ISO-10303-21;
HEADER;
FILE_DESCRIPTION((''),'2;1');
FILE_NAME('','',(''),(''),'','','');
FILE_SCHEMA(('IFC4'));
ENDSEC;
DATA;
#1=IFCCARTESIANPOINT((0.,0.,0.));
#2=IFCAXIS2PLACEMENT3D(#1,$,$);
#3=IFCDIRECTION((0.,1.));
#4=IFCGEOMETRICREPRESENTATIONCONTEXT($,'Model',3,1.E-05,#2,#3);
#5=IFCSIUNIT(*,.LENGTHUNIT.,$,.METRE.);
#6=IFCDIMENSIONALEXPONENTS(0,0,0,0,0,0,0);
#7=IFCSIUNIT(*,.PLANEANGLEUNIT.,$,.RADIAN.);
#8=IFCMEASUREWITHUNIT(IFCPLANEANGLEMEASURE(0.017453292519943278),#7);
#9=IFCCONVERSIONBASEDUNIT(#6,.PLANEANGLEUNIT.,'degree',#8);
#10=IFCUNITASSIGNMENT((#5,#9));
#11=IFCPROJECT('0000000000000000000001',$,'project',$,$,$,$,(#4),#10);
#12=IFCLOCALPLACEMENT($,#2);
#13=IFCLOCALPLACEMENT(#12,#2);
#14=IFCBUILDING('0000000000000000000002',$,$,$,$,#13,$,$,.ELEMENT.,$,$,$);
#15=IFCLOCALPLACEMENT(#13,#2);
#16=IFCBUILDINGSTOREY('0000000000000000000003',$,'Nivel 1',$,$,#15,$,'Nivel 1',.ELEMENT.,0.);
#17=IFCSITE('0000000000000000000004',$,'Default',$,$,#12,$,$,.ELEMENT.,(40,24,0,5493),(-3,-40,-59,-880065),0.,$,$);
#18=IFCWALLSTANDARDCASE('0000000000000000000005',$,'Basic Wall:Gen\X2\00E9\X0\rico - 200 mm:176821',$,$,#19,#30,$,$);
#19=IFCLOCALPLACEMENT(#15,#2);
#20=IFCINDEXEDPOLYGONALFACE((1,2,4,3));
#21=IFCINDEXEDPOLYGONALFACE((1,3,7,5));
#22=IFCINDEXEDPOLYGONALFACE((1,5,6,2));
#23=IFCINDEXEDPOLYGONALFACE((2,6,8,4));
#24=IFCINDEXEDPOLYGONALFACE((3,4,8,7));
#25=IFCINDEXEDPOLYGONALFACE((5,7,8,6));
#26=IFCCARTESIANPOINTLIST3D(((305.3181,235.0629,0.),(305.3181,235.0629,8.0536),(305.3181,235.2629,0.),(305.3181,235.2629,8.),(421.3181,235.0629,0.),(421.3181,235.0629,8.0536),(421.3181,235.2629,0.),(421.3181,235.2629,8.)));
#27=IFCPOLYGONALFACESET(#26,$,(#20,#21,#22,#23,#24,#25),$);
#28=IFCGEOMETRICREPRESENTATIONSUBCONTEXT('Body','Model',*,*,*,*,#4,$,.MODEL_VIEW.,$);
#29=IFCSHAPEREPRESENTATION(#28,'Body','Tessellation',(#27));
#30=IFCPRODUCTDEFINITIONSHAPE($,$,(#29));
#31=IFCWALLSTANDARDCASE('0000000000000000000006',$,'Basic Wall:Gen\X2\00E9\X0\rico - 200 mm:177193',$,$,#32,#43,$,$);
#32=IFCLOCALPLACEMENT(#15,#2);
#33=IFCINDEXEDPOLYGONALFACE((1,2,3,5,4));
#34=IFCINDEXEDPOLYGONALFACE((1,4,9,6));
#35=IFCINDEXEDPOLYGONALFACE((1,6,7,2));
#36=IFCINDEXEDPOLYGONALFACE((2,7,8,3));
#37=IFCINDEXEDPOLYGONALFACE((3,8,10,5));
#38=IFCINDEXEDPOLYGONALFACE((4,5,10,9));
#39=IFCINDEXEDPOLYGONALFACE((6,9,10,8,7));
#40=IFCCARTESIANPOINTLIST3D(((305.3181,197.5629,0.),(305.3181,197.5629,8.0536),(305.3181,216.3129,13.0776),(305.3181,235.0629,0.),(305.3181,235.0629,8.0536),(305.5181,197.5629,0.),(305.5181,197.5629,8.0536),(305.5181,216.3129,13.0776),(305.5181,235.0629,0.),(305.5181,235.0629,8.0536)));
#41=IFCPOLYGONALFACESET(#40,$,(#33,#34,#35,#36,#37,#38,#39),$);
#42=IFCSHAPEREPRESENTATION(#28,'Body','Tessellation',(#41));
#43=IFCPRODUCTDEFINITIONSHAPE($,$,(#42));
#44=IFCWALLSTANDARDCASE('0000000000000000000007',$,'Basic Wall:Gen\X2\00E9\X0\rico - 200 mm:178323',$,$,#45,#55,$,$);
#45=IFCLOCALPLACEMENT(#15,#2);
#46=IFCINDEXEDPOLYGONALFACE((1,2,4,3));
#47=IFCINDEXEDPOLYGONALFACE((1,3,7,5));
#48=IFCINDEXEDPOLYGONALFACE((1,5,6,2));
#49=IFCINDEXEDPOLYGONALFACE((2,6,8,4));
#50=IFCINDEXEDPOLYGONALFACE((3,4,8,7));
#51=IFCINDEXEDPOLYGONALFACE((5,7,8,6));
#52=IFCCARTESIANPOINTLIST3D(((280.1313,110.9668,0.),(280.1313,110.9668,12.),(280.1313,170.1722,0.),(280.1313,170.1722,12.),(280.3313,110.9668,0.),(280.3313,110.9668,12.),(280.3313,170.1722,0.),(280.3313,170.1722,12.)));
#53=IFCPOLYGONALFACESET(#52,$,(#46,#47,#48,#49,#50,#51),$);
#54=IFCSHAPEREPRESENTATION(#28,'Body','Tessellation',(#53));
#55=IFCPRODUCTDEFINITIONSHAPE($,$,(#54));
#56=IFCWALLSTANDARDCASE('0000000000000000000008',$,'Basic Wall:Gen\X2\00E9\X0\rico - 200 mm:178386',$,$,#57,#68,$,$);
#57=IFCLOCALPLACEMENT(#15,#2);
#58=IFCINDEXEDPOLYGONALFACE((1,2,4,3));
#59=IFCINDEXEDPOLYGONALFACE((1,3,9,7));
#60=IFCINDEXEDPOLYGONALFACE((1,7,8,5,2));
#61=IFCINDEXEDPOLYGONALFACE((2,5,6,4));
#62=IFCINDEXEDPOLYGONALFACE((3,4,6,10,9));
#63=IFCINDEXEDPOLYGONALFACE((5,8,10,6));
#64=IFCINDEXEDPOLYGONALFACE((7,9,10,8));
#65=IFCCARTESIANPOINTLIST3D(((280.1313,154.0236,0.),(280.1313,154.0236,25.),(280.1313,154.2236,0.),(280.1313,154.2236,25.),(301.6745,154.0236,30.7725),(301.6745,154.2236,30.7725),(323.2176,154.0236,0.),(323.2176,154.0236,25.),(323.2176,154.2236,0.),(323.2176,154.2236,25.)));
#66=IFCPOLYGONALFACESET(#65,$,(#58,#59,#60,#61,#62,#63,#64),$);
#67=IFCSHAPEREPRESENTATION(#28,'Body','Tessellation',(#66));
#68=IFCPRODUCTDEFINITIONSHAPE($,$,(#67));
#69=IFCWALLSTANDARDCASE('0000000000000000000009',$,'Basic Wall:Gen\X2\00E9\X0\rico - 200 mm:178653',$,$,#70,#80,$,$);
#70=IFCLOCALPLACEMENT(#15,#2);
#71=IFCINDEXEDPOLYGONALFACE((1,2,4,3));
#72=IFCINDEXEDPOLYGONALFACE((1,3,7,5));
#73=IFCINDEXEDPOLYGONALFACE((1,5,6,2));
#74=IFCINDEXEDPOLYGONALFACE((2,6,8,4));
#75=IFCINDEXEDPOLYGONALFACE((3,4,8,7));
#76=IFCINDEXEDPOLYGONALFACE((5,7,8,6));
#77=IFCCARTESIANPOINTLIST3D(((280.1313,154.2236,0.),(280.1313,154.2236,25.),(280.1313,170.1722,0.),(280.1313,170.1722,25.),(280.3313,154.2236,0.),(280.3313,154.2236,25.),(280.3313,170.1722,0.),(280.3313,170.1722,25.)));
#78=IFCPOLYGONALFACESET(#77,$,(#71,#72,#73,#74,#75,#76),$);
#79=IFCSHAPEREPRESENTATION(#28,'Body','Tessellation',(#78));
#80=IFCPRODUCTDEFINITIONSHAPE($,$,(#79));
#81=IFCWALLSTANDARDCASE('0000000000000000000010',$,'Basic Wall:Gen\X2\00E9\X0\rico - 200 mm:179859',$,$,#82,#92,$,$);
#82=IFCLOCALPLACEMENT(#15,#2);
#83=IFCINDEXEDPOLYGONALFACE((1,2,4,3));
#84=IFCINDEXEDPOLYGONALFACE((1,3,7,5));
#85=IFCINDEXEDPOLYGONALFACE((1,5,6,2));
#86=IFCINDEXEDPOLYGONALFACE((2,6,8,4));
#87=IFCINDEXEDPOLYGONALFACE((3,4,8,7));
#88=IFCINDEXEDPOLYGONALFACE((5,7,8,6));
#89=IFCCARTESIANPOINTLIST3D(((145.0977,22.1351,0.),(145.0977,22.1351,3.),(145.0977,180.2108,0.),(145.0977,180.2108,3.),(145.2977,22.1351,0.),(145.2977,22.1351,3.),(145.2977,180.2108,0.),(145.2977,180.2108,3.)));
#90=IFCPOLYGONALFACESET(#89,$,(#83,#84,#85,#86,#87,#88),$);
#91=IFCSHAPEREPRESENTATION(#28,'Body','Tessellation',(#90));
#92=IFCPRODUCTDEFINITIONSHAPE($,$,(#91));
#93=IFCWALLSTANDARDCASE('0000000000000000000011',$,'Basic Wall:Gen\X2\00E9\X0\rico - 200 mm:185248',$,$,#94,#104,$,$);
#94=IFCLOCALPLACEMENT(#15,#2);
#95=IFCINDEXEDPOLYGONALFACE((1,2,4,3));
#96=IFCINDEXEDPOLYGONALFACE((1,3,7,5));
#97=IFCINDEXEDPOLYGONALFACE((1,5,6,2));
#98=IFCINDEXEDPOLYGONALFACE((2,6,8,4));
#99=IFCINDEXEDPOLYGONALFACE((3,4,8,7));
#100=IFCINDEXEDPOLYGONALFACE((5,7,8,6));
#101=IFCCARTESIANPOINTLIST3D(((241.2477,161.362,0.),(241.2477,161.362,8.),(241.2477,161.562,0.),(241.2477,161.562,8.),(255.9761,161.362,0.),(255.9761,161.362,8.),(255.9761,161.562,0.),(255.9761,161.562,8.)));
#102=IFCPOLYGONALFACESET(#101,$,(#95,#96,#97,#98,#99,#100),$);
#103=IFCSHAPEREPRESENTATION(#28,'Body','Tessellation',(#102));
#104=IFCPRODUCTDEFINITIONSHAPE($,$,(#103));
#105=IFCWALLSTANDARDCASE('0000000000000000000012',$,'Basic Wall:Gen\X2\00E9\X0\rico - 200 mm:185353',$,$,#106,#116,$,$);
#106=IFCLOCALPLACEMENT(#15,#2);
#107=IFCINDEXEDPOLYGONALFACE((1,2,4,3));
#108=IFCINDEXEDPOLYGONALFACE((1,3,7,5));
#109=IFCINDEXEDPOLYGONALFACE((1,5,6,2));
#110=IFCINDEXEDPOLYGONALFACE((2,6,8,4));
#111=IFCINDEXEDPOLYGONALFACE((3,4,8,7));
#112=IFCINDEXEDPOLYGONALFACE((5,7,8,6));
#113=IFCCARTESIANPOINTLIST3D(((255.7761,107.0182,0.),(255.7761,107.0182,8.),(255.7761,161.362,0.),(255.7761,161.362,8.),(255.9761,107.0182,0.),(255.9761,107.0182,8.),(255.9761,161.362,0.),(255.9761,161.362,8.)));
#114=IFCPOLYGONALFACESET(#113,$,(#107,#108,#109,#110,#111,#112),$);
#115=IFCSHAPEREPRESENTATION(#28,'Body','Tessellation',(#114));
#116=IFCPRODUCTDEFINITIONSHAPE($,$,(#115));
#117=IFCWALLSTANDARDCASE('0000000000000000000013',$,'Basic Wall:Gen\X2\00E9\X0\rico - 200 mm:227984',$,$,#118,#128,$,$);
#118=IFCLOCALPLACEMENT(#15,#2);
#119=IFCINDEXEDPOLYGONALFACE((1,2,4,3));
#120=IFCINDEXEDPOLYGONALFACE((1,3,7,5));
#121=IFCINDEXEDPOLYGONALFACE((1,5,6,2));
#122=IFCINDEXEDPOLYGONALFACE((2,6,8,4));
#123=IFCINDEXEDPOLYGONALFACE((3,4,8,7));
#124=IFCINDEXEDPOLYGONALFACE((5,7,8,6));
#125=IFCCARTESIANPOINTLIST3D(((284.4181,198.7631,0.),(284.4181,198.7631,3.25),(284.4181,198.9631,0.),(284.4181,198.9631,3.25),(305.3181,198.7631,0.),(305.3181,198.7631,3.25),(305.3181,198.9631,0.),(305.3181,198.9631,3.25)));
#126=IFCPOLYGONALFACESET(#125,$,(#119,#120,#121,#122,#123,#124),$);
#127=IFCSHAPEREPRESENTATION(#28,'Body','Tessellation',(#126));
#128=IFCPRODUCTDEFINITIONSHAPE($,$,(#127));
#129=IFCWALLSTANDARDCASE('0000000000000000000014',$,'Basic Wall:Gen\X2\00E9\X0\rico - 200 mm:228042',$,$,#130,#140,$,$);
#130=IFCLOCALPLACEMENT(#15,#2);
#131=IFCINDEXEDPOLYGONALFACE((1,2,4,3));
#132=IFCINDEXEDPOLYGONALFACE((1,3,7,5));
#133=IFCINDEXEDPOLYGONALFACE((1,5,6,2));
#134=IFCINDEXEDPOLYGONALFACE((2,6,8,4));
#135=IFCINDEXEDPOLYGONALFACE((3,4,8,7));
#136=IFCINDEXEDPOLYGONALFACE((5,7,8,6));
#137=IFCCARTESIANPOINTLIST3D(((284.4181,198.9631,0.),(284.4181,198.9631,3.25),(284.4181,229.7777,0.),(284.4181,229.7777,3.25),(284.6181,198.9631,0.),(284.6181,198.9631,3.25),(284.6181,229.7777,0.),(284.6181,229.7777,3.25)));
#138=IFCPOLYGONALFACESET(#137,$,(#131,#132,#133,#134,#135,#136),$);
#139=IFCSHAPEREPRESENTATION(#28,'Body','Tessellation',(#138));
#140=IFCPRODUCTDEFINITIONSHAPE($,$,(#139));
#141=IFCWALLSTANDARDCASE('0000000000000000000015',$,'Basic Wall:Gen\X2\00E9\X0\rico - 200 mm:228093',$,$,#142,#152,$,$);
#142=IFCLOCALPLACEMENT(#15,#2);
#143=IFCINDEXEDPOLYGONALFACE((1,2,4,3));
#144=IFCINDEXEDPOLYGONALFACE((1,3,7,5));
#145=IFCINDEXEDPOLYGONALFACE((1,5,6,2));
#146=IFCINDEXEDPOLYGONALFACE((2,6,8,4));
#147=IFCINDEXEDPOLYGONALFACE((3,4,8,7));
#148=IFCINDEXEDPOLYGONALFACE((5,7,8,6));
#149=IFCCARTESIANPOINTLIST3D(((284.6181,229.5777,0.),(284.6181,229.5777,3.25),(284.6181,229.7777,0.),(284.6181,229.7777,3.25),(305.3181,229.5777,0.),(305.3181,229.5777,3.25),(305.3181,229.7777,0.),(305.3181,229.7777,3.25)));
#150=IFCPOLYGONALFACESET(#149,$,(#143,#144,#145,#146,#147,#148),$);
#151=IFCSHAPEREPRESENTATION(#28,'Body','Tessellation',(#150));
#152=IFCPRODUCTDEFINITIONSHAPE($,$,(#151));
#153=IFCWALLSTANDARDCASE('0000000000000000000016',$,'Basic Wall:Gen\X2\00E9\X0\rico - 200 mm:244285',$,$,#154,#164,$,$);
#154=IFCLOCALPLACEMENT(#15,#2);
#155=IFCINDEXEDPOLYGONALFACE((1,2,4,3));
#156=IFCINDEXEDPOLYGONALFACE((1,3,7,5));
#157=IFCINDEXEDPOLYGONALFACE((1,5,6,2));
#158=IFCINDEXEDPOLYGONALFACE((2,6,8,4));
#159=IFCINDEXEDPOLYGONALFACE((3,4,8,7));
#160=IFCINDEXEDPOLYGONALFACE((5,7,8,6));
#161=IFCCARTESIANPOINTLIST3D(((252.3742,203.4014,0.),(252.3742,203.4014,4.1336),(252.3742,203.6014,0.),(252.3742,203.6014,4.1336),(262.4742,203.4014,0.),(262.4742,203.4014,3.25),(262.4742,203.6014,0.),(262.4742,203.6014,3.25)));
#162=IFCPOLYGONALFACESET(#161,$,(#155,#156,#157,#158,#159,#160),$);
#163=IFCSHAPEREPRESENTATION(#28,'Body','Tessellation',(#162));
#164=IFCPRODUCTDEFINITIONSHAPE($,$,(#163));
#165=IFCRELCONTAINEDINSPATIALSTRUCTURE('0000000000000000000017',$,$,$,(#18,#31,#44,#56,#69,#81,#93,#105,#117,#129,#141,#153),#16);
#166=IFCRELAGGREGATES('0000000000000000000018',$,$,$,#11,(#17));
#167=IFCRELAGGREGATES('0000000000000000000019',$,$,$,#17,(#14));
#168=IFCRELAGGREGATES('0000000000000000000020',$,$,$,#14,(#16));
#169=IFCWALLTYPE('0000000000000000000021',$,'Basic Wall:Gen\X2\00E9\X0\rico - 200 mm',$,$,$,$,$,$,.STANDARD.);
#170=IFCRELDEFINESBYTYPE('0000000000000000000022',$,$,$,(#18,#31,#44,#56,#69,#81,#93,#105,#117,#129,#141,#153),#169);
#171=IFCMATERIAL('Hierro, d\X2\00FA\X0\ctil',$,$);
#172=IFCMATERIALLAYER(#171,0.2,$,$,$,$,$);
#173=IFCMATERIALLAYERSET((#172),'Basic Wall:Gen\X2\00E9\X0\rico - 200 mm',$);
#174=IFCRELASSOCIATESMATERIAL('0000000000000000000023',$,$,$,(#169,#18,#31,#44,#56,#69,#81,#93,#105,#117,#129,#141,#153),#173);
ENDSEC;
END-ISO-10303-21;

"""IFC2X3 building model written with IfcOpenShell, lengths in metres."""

from ifc_helpers import new_model, entity, si_unit, converted_unit, direction, frame, frame_2d, origin, place, context, subcontext, project, spatial, polyline, rectangle, extrude, clip, bounded_halfspace, material, layer, layer_set, layer_usage, type_object, element, save


model = new_model("IFC2X3")

# Units and contexts
model_context = context("Model", 3, precision=1e-05, world=origin(), true_north=direction((0.0, 1.0)))
body_context = subcontext(model_context, "Body", "Model", "MODEL_VIEW")
ifc_project = project(units=[si_unit("LENGTHUNIT", "METRE"), converted_unit("PLANEANGLEUNIT", "degree", entity("IfcPlaneAngleMeasure", 0.017453292519943278), si_unit("PLANEANGLEUNIT", "RADIAN"), dimensions=[0, 0, 0, 0, 0, 0, 0])], contexts=[model_context])

# Site, building, storey
site_placement = place(None, origin())
site = spatial("IfcSite", under=ifc_project, at=site_placement, Name="Default", CompositionType="ELEMENT", RefLatitude=(40, 24, 0, 5493), RefLongitude=(-3, -40, -59, -880065), RefElevation=0.0)
building_placement = place(site_placement, origin())
building = spatial("IfcBuilding", under=site, at=building_placement, CompositionType="ELEMENT")
storey_placement = place(building_placement, origin())
storey = spatial("IfcBuildingStorey", under=building, at=storey_placement, Name="Nivel 1", LongName="Nivel 1", CompositionType="ELEMENT", Elevation=0.0)

# Walls
ifc_material_1 = material(Name="Hierro, dúctil")
ifc_layer_1 = layer(ifc_material_1, 0.2)
ifc_layer_set_1 = layer_set([ifc_layer_1], Name="Basic Wall:Genérico - 200 mm")
wall_type = type_object("IfcWallType", Name="Basic Wall:Genérico - 200 mm", PredefinedType="STANDARD", material=ifc_layer_set_1)
ifc_layer_usage_1 = layer_usage(ifc_layer_set_1, "AXIS2", "NEGATIVE", 0.1)
wall_1_placement = place(storey_placement, frame((305.3181, 235.1629, 0.0)))
element("IfcWallStandardCase", 1, at=wall_1_placement, inside=storey, type_object=wall_type, material=ifc_layer_usage_1, Name="Basic Wall:Genérico - 200 mm:176821", context=body_context, shape_type="Clipping", body=[
    clip(extrude(rectangle(XDim=116.0, YDim=0.2, at=frame_2d((58.0, 0.0), x_axis=(-1.0, 0.0))), origin(), (0.0, 0.0, 1.0), 8.0536), bounded_halfspace(frame((0.0, -0.1, 8.0536), z_axis=(0.0, 0.258819, 0.965926), x_axis=(-1.0, 0.0, 0.0)), False, frame((0.0, -0.1, 8.0536)), polyline([(0.0, 0.0), (0.2, 0.0), (115.8, 0.0), (116.0, 0.0), (116.0, 0.2), (0.0, 0.2), (0.0, 0.0)]))),
])
ifc_layer_usage_2 = layer_usage(ifc_layer_set_1, "AXIS2", "NEGATIVE", 0.1)
wall_2_placement = place(storey_placement, frame((305.4181, 197.5629, 0.0), z_axis=(0.0, 0.0, 1.0), x_axis=(0.0, 1.0, 0.0)))
element("IfcWallStandardCase", 2, at=wall_2_placement, inside=storey, type_object=wall_type, material=ifc_layer_usage_2, Name="Basic Wall:Genérico - 200 mm:177193", context=body_context, shape_type="Clipping", body=[
    clip(clip(extrude(rectangle(XDim=37.5, YDim=0.2, at=frame_2d((18.75, 0.0), x_axis=(-1.0, 0.0))), origin(), (0.0, 0.0, 1.0), 13.0776), bounded_halfspace(frame((18.75, -0.1, 13.0776), z_axis=(0.258819, 0.0, 0.965926), x_axis=(0.0, 1.0, 0.0)), False, frame((18.75, -0.1, 13.0776)), polyline([(0.0, 0.0), (18.75, 0.0), (18.75, 0.2), (0.0, 0.2), (0.0, 0.0)]))), bounded_halfspace(frame((0.0, -0.1, 8.0536), z_axis=(-0.258819, 0.0, 0.965926), x_axis=(0.0, -1.0, 0.0)), False, frame((0.0, -0.1, 8.0536)), polyline([(0.0, 0.0), (18.75, 0.0), (18.75, 0.2), (0.0, 0.2), (0.0, 0.0)]))),
])
ifc_layer_usage_3 = layer_usage(ifc_layer_set_1, "AXIS2", "NEGATIVE", 0.1)
wall_3_placement = place(storey_placement, frame((280.2313, 170.1722, 0.0), z_axis=(0.0, 0.0, 1.0), x_axis=(0.0, -1.0, 0.0)))
element("IfcWallStandardCase", 3, at=wall_3_placement, inside=storey, type_object=wall_type, material=ifc_layer_usage_3, Name="Basic Wall:Genérico - 200 mm:178323", context=body_context, shape_type="SweptSolid", body=[
    extrude(rectangle(XDim=59.2055, YDim=0.2, at=frame_2d((29.6027, 0.0), x_axis=(-1.0, 0.0))), origin(), (0.0, 0.0, 1.0), 12.0),
])
ifc_layer_usage_4 = layer_usage(ifc_layer_set_1, "AXIS2", "POSITIVE", -0.1)
wall_4_placement = place(storey_placement, frame((280.1313, 154.1236, 0.0)))
element("IfcWallStandardCase", 4, at=wall_4_placement, inside=storey, type_object=wall_type, material=ifc_layer_usage_4, Name="Basic Wall:Genérico - 200 mm:178386", context=body_context, shape_type="Clipping", body=[
    clip(clip(extrude(rectangle(XDim=43.0863, YDim=0.2, at=frame_2d((21.5432, 0.0), x_axis=(-1.0, 0.0))), origin(), (0.0, 0.0, 1.0), 30.7725), bounded_halfspace(frame((0.0, -0.1, 25.0), z_axis=(-0.258819, 0.0, 0.965926), x_axis=(0.0, -1.0, 0.0)), False, frame((0.0, -0.1, 25.0)), polyline([(0.0, 0.0), (21.5432, 0.0), (21.5432, 0.2), (0.0, 0.2), (0.0, 0.0)]))), bounded_halfspace(frame((21.5432, -0.1, 30.7725), z_axis=(0.258819, 0.0, 0.965926), x_axis=(0.0, 1.0, 0.0)), False, frame((21.5432, -0.1, 30.7725)), polyline([(0.0, 0.0), (21.5432, 0.0), (21.5432, 0.2), (0.0, 0.2), (0.0, 0.0)]))),
])
ifc_layer_usage_5 = layer_usage(ifc_layer_set_1, "AXIS2", "NEGATIVE", 0.1)
wall_5_placement = place(storey_placement, frame((280.2313, 170.1722, 0.0), z_axis=(0.0, 0.0, 1.0), x_axis=(0.0, -1.0, 0.0)))
element("IfcWallStandardCase", 5, at=wall_5_placement, inside=storey, type_object=wall_type, material=ifc_layer_usage_5, Name="Basic Wall:Genérico - 200 mm:178653", context=body_context, shape_type="SweptSolid", body=[
    extrude(rectangle(XDim=15.9486, YDim=0.2, at=frame_2d((7.9743, 0.0), x_axis=(-1.0, 0.0))), origin(), (0.0, 0.0, 1.0), 25.0),
])
ifc_layer_usage_6 = layer_usage(ifc_layer_set_1, "AXIS2", "NEGATIVE", 0.1)
wall_6_placement = place(storey_placement, frame((145.1977, 180.2108, 0.0), z_axis=(0.0, 0.0, 1.0), x_axis=(0.0, -1.0, 0.0)))
element("IfcWallStandardCase", 6, at=wall_6_placement, inside=storey, type_object=wall_type, material=ifc_layer_usage_6, Name="Basic Wall:Genérico - 200 mm:179859", context=body_context, shape_type="SweptSolid", body=[
    extrude(rectangle(XDim=158.0757, YDim=0.2, at=frame_2d((79.0379, 0.0), x_axis=(-1.0, 0.0))), origin(), (0.0, 0.0, 1.0), 3.0),
])
ifc_layer_usage_7 = layer_usage(ifc_layer_set_1, "AXIS2", "NEGATIVE", 0.1)
wall_7_placement = place(storey_placement, frame((241.2477, 161.462, 0.0)))
element("IfcWallStandardCase", 7, at=wall_7_placement, inside=storey, type_object=wall_type, material=ifc_layer_usage_7, Name="Basic Wall:Genérico - 200 mm:185248", context=body_context, shape_type="SweptSolid", body=[
    extrude(rectangle(XDim=14.7284, YDim=0.2, at=frame_2d((7.3642, 0.0), x_axis=(-1.0, 0.0))), origin(), (0.0, 0.0, 1.0), 8.0),
])
ifc_layer_usage_8 = layer_usage(ifc_layer_set_1, "AXIS2", "NEGATIVE", 0.1)
wall_8_placement = place(storey_placement, frame((255.8761, 161.362, 0.0), z_axis=(0.0, 0.0, 1.0), x_axis=(0.0, -1.0, 0.0)))
element("IfcWallStandardCase", 8, at=wall_8_placement, inside=storey, type_object=wall_type, material=ifc_layer_usage_8, Name="Basic Wall:Genérico - 200 mm:185353", context=body_context, shape_type="SweptSolid", body=[
    extrude(rectangle(XDim=54.3438, YDim=0.2, at=frame_2d((27.1719, 0.0), x_axis=(-1.0, 0.0))), origin(), (0.0, 0.0, 1.0), 8.0),
])
ifc_layer_usage_9 = layer_usage(ifc_layer_set_1, "AXIS2", "NEGATIVE", 0.1)
wall_9_placement = place(storey_placement, frame((305.3181, 198.8631, 0.0), z_axis=(0.0, 0.0, 1.0), x_axis=(-1.0, 0.0, 0.0)))
element("IfcWallStandardCase", 9, at=wall_9_placement, inside=storey, type_object=wall_type, material=ifc_layer_usage_9, Name="Basic Wall:Genérico - 200 mm:227984", context=body_context, shape_type="Clipping", body=[
    clip(extrude(rectangle(XDim=20.9, YDim=0.2, at=frame_2d((10.45, 0.0), x_axis=(-1.0, 0.0))), origin(), (0.0, 0.0, 1.0), 3.25), bounded_halfspace(frame((0.0, -0.1, 3.25), z_axis=(0.0, 0.0, 1.0), x_axis=(-1.0, 0.0, 0.0)), False, frame((0.0, -0.1, 3.25)), polyline([(0.0, 0.0), (20.7, 0.0), (20.9, 0.0), (20.9, 0.2), (0.0, 0.2), (0.0, 0.0)]))),
])
ifc_layer_usage_10 = layer_usage(ifc_layer_set_1, "AXIS2", "NEGATIVE", 0.1)
wall_10_placement = place(storey_placement, frame((284.5181, 198.9631, 0.0), z_axis=(0.0, 0.0, 1.0), x_axis=(0.0, 1.0, 0.0)))
element("IfcWallStandardCase", 10, at=wall_10_placement, inside=storey, type_object=wall_type, material=ifc_layer_usage_10, Name="Basic Wall:Genérico - 200 mm:228042", context=body_context, shape_type="Clipping", body=[
    clip(extrude(rectangle(XDim=30.8146, YDim=0.2, at=frame_2d((15.4073, 0.0), x_axis=(-1.0, 0.0))), origin(), (0.0, 0.0, 1.0), 3.25), bounded_halfspace(frame((0.0, -0.1, 3.25), z_axis=(0.0, 0.0, 1.0), x_axis=(0.0, -1.0, 0.0)), False, frame((0.0, -0.1, 3.25)), polyline([(0.0, 0.0), (30.6146, 0.0), (30.8146, 0.0), (30.8146, 0.2), (0.0, 0.2), (0.0, 0.0)]))),
])
ifc_layer_usage_11 = layer_usage(ifc_layer_set_1, "AXIS2", "NEGATIVE", 0.1)
wall_11_placement = place(storey_placement, frame((284.6181, 229.6777, 0.0)))
element("IfcWallStandardCase", 11, at=wall_11_placement, inside=storey, type_object=wall_type, material=ifc_layer_usage_11, Name="Basic Wall:Genérico - 200 mm:228093", context=body_context, shape_type="Clipping", body=[
    clip(extrude(rectangle(XDim=20.7, YDim=0.2, at=frame_2d((10.35, 0.0), x_axis=(-1.0, 0.0))), origin(), (0.0, 0.0, 1.0), 3.25), bounded_halfspace(frame((0.0, -0.1, 3.25)), False, frame((0.0, -0.1, 3.25)), polyline([(0.0, 0.0), (20.7, 0.0), (20.7, 0.2), (0.0, 0.2), (0.0, 0.0)]))),
])
ifc_layer_usage_12 = layer_usage(ifc_layer_set_1, "AXIS2", "NEGATIVE", 0.1)
wall_12_placement = place(storey_placement, frame((252.3742, 203.5014, 0.0)))
element("IfcWallStandardCase", 12, at=wall_12_placement, inside=storey, type_object=wall_type, material=ifc_layer_usage_12, Name="Basic Wall:Genérico - 200 mm:244285", context=body_context, shape_type="Clipping", body=[
    clip(extrude(rectangle(XDim=10.1, YDim=0.2, at=frame_2d((5.05, 0.0), x_axis=(-1.0, 0.0))), origin(), (0.0, 0.0, 1.0), 4.1336), bounded_halfspace(frame((0.0, -0.1, 4.1336), z_axis=(0.087156, 0.0, 0.996195), x_axis=(0.0, 1.0, 0.0)), False, frame((0.0, -0.1, 4.1336)), polyline([(0.0, 0.0), (10.1, 0.0), (10.1, 0.2), (9.9, 0.2), (0.0, 0.2), (0.0, 0.0)]))),
])

save(model, "model.ifc")
